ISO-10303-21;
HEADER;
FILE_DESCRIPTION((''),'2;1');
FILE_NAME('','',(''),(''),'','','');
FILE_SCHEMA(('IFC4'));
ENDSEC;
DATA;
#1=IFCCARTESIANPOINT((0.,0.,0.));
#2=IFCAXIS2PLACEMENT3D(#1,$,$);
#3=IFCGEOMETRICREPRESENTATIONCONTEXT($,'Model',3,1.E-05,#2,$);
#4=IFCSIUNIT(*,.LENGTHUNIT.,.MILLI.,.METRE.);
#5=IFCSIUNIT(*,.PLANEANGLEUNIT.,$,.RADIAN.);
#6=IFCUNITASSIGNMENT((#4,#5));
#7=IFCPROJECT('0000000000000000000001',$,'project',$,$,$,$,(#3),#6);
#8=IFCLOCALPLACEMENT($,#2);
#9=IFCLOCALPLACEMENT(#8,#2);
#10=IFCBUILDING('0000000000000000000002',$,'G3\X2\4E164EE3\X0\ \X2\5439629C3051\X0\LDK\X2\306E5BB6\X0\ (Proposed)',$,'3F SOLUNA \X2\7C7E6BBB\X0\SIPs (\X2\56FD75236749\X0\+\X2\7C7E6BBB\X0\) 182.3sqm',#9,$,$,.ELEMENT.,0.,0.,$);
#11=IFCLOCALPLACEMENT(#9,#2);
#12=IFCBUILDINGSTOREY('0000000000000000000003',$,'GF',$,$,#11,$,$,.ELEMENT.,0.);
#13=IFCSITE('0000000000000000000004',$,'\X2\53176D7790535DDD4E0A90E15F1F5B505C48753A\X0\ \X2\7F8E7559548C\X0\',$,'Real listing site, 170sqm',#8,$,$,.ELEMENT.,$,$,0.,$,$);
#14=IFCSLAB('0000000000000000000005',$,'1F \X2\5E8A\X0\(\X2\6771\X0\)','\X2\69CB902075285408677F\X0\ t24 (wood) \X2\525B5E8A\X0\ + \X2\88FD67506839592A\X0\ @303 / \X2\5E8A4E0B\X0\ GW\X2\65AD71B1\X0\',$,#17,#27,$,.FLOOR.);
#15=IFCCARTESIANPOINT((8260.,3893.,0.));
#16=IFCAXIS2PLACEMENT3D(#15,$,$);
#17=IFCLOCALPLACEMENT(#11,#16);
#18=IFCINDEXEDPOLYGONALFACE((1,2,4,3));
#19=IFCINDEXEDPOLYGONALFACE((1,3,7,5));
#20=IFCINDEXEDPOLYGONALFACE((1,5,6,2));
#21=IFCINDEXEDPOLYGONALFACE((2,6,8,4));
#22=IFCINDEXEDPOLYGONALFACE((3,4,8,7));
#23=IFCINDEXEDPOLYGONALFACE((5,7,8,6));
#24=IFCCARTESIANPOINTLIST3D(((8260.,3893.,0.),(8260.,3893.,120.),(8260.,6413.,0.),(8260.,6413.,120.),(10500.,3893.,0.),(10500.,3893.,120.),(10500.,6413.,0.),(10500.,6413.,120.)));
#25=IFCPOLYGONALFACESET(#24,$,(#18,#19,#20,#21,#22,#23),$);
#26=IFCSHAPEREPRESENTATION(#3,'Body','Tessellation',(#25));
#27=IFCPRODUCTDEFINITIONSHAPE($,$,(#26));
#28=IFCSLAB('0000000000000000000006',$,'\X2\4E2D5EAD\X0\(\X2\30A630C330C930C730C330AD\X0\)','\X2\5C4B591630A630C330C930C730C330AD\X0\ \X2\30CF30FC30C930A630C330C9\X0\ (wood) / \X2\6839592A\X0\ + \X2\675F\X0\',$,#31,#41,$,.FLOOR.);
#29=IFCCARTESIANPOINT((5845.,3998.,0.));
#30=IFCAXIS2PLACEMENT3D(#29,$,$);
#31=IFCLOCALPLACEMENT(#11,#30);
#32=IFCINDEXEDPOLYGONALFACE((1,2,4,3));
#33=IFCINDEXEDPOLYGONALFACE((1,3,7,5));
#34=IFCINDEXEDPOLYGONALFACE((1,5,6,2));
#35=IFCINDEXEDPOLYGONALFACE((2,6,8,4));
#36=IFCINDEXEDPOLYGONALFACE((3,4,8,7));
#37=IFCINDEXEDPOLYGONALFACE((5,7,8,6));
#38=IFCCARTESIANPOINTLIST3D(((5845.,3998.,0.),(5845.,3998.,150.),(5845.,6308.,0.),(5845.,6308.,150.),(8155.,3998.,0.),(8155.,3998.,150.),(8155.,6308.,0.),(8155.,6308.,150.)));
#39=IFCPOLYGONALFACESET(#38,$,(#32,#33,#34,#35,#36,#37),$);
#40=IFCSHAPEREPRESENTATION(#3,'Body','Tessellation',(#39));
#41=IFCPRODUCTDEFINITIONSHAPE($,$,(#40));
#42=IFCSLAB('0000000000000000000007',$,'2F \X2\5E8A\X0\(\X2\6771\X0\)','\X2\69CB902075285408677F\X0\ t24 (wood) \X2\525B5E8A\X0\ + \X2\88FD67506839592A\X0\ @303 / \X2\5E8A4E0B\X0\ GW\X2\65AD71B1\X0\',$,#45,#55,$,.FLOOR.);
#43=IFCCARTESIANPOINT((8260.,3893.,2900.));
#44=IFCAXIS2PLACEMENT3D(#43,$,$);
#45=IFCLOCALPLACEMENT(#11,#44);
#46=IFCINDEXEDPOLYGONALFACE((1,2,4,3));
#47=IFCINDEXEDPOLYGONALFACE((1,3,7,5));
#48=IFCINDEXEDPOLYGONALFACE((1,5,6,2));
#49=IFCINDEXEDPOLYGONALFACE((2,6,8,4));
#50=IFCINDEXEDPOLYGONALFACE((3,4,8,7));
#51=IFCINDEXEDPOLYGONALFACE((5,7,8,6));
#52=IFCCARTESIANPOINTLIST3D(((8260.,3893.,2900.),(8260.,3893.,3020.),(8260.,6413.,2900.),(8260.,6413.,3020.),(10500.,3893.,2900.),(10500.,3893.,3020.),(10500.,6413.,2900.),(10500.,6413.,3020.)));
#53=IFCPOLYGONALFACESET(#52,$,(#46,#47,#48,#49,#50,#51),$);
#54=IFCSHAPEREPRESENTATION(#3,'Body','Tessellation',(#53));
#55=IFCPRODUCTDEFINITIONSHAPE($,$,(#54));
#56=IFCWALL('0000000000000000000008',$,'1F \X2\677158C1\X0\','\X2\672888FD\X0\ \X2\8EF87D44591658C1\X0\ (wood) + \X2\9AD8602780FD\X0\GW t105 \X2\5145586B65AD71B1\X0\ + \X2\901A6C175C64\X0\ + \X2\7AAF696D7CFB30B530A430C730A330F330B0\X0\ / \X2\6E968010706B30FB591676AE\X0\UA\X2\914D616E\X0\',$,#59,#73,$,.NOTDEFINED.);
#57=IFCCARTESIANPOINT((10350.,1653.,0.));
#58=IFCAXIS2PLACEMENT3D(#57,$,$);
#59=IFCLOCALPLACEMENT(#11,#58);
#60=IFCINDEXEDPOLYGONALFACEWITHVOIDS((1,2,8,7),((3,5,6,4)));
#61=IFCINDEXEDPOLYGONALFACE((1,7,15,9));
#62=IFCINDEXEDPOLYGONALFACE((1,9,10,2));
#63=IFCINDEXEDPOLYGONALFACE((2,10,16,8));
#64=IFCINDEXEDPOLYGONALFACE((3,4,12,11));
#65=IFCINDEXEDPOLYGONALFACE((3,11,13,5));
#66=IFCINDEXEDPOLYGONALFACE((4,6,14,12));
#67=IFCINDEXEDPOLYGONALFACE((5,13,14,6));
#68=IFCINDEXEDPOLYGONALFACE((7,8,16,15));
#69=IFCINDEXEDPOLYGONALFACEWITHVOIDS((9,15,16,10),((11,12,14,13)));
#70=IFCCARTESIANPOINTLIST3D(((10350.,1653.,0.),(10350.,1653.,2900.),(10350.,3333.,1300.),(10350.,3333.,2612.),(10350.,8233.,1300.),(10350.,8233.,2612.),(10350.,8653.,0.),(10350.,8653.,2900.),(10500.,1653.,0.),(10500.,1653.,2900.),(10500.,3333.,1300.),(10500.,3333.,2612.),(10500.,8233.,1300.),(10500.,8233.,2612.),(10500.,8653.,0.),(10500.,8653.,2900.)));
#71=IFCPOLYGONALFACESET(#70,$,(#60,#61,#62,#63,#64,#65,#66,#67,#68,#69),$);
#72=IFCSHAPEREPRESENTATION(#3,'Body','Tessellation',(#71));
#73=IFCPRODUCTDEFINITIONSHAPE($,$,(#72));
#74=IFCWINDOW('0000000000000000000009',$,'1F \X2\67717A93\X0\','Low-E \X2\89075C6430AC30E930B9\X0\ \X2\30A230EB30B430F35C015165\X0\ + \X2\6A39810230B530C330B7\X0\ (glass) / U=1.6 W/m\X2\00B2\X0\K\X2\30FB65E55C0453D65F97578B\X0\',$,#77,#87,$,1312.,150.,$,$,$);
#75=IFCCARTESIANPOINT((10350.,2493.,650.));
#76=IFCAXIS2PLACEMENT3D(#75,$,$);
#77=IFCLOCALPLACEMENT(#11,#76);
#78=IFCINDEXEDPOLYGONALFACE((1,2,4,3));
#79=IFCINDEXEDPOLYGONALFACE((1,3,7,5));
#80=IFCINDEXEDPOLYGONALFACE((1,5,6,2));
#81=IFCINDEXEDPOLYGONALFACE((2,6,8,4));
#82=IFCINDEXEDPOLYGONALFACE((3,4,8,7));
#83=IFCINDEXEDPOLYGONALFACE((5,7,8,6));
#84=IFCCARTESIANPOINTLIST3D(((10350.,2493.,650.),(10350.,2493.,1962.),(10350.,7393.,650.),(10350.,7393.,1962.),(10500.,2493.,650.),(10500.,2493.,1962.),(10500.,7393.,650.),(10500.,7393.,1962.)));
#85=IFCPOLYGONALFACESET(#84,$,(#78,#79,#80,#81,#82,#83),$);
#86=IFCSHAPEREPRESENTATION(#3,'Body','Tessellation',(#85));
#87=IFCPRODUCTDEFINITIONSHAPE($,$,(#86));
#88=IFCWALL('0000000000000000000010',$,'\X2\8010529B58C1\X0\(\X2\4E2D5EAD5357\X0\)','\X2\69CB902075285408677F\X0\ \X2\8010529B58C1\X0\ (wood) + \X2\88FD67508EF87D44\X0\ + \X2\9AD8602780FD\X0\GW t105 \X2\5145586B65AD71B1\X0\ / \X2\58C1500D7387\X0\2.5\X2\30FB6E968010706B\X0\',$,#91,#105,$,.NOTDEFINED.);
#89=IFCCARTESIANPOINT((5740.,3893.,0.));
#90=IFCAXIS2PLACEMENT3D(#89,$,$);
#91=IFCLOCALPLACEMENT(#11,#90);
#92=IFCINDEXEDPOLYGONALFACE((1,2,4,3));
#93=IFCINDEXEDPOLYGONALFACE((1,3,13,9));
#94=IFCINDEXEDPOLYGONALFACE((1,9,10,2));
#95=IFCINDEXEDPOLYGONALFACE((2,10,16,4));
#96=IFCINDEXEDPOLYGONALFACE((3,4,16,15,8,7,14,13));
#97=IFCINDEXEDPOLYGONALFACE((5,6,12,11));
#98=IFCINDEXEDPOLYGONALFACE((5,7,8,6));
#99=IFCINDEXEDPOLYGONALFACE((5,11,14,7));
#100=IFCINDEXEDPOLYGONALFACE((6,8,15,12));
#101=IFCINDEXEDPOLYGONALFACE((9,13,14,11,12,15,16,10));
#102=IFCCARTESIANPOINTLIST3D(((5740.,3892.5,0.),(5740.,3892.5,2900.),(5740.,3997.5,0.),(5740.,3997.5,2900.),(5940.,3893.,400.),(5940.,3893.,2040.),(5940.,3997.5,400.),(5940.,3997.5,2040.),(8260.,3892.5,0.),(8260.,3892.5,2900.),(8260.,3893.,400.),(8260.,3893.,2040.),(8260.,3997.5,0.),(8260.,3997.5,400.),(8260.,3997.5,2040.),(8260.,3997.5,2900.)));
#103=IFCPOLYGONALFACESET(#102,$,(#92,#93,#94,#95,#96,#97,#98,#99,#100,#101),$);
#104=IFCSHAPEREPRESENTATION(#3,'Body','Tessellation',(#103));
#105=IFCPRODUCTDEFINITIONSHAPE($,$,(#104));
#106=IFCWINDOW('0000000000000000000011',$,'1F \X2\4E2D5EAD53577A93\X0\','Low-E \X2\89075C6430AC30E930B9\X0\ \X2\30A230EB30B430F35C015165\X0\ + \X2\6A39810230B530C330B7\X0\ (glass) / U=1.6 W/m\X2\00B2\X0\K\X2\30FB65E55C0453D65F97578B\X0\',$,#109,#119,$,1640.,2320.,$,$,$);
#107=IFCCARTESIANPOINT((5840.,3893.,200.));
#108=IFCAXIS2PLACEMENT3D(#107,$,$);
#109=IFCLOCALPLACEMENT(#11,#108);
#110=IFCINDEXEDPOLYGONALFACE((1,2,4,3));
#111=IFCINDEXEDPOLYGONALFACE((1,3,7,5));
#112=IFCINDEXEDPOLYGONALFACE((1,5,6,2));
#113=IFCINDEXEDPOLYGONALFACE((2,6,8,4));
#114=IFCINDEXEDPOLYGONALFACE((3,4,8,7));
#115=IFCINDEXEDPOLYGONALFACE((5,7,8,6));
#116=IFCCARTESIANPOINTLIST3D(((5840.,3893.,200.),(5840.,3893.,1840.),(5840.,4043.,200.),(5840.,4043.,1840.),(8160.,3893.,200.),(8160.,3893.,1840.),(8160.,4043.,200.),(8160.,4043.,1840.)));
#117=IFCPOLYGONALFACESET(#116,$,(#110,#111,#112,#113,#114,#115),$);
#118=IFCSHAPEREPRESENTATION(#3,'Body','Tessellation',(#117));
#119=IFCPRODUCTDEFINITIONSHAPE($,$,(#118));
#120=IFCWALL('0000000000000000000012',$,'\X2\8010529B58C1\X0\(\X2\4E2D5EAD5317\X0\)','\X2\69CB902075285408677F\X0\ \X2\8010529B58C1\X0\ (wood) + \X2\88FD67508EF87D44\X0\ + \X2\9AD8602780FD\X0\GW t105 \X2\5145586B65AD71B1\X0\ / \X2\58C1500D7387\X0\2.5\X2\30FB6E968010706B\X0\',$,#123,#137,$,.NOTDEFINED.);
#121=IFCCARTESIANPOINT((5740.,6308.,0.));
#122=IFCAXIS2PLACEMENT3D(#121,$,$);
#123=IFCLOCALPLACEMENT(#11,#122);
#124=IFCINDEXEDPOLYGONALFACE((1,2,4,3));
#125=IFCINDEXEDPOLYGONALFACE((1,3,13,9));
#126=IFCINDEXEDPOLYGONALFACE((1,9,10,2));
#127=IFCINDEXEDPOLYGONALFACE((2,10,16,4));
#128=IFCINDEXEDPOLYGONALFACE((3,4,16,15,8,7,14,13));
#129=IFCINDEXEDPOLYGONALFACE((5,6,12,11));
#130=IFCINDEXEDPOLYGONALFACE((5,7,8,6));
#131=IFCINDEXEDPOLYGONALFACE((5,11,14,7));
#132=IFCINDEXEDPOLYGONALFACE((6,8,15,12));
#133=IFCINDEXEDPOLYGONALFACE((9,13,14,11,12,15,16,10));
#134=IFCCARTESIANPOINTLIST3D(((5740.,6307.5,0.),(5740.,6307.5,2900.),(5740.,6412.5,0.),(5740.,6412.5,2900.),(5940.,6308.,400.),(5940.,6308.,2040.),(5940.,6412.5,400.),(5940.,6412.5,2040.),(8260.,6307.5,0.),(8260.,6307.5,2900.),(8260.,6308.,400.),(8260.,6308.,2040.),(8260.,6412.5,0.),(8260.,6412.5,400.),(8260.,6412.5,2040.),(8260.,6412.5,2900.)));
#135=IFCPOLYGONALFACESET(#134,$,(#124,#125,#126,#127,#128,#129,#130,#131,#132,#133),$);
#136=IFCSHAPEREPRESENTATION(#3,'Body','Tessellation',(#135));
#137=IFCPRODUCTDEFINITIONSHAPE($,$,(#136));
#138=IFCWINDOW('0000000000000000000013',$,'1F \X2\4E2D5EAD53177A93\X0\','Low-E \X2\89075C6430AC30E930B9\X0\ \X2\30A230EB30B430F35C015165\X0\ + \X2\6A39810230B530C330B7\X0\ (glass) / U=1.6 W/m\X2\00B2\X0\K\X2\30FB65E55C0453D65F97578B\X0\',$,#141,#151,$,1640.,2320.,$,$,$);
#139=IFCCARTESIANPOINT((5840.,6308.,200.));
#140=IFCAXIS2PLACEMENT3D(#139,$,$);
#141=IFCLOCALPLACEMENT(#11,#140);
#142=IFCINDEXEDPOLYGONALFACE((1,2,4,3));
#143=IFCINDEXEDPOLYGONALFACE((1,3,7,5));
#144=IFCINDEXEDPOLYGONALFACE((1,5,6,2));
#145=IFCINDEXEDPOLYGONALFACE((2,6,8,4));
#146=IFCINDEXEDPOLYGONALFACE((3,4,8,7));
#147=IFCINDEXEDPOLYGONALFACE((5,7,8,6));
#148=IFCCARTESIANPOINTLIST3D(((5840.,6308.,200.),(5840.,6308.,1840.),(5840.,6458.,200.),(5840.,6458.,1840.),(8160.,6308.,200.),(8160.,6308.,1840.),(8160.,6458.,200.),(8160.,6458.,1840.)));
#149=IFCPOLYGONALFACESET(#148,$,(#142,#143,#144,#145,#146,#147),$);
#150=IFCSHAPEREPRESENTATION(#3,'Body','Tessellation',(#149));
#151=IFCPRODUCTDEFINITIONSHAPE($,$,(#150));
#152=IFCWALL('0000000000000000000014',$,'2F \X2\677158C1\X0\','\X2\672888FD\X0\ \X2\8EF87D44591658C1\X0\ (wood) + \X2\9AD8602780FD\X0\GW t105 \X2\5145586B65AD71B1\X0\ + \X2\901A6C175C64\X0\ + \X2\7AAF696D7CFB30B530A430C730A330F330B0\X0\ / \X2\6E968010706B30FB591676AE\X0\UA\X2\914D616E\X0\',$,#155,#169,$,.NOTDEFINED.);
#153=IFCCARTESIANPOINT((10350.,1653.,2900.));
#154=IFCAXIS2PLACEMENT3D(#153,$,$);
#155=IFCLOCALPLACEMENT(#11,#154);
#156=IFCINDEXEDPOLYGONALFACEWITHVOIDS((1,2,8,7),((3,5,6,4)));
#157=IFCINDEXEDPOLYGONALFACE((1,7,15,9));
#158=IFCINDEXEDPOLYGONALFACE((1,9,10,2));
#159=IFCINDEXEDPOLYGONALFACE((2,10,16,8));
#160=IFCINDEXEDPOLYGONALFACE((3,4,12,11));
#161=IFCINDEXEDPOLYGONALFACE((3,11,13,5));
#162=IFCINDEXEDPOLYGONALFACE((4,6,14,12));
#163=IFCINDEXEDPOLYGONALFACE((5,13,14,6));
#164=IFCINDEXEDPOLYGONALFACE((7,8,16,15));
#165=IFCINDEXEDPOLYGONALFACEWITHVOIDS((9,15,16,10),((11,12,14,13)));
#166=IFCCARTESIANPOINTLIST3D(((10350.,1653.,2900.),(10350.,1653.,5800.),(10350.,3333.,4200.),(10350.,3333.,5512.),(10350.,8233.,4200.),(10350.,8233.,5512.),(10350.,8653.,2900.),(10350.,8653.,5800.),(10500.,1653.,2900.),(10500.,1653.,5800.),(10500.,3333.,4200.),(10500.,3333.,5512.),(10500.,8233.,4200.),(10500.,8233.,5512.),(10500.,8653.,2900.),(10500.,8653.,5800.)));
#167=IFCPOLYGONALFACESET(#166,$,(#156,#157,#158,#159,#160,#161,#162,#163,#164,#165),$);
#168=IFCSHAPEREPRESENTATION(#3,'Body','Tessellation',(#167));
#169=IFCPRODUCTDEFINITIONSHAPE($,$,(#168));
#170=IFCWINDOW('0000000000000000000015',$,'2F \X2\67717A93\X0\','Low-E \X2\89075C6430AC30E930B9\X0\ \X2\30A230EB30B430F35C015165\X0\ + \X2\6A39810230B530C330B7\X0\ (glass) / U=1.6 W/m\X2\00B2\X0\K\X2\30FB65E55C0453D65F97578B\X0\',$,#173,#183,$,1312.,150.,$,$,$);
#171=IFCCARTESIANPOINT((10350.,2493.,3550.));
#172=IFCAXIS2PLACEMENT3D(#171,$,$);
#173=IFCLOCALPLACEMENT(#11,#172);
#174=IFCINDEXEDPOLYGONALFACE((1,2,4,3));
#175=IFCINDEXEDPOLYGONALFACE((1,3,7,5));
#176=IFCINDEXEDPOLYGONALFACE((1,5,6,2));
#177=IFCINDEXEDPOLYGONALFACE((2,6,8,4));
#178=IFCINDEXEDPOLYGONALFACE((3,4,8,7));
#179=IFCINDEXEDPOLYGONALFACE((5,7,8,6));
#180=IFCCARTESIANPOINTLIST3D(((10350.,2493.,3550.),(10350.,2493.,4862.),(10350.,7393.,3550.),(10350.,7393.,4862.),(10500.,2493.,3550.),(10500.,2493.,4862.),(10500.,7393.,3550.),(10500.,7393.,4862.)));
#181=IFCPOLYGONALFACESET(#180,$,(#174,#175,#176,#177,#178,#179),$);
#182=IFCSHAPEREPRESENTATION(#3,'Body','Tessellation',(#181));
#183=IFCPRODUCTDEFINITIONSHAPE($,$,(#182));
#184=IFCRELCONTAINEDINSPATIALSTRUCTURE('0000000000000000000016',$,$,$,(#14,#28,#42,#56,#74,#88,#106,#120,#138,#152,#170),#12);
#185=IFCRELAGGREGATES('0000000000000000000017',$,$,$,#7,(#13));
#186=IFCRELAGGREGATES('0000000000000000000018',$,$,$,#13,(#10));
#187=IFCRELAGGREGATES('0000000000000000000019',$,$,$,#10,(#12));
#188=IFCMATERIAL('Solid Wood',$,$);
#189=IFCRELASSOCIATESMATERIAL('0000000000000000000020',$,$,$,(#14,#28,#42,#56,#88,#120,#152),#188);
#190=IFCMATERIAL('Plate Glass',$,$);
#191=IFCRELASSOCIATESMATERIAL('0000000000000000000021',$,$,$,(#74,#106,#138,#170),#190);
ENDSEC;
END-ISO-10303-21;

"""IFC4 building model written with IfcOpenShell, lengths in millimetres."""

from ifc_helpers import new_model, si_unit, frame, frame_2d, origin, place, context, project, spatial, rectangle, extrude, material, element, fill, save


model = new_model("IFC4")

# Units and contexts
model_context = context("Model", 3, precision=1e-05, world=origin())
ifc_project = project(units=[si_unit("LENGTHUNIT", "METRE", prefix="MILLI"), si_unit("PLANEANGLEUNIT", "RADIAN")], contexts=[model_context])

# Site, building, storey
site_placement = place(None, origin())
site = spatial("IfcSite", under=ifc_project, at=site_placement, Name="北海道川上郡弟子屈町 美留和", ObjectType="Real listing site, 170sqm", CompositionType="ELEMENT", RefElevation=0.0)
building_placement = place(site_placement, origin())
building = spatial("IfcBuilding", under=site, at=building_placement, Name="G3世代 吹抜けLDKの家 (Proposed)", ObjectType="3F SOLUNA 籾殻SIPs (国産杉+籾殻) 182.3sqm", CompositionType="ELEMENT", ElevationOfRefHeight=0.0, ElevationOfTerrain=0.0)
storey_placement = place(building_placement, origin())
storey = spatial("IfcBuildingStorey", under=building, at=storey_placement, Name="GF", CompositionType="ELEMENT", Elevation=0.0)

# Slabs
ifc_material_1 = material(Name="Solid Wood")
slab_1_placement = place(storey_placement, frame((8260.0, 3893.0, 0.0)))
element("IfcSlab", 1, at=slab_1_placement, inside=storey, material=ifc_material_1, Name="1F 床(東)", Description="構造用合板 t24 (wood) 剛床 + 製材根太 @303 / 床下 GW断熱", PredefinedType="FLOOR", context=model_context, shape_type="SweptSolid", body=[
    extrude(rectangle(XDim=2240.0, YDim=2520.0, at=frame_2d((1120.0, 1260.0))), frame((8260.0, 3893.0, 0.0)), (0.0, 0.0, 1.0), 120.0),
])
slab_2_placement = place(storey_placement, frame((5845.0, 3998.0, 0.0)))
element("IfcSlab", 2, at=slab_2_placement, inside=storey, material=ifc_material_1, Name="中庭(ウッドデッキ)", Description="屋外ウッドデッキ ハードウッド (wood) / 根太 + 束", PredefinedType="FLOOR", context=model_context, shape_type="SweptSolid", body=[
    extrude(rectangle(XDim=2310.0, YDim=2310.0, at=frame_2d((1155.0, 1155.0))), frame((5845.0, 3998.0, 0.0)), (0.0, 0.0, 1.0), 150.0),
])
slab_3_placement = place(storey_placement, frame((8260.0, 3893.0, 2900.0)))
element("IfcSlab", 3, at=slab_3_placement, inside=storey, material=ifc_material_1, Name="2F 床(東)", Description="構造用合板 t24 (wood) 剛床 + 製材根太 @303 / 床下 GW断熱", PredefinedType="FLOOR", context=model_context, shape_type="SweptSolid", body=[
    extrude(rectangle(XDim=2240.0, YDim=2520.0, at=frame_2d((1120.0, 1260.0))), frame((8260.0, 3893.0, 2900.0)), (0.0, 0.0, 1.0), 120.0),
])

# Walls, openings, windows
wall_1_placement = place(storey_placement, frame((10350.0, 1653.0, 0.0)))
wall_1 = element("IfcWall", 4, at=wall_1_placement, inside=storey, material=ifc_material_1, Name="1F 東壁", Description="木製 軸組外壁 (wood) + 高性能GW t105 充填断熱 + 通気層 + 窯業系サイディング / 準耐火・外皮UA配慮", PredefinedType="NOTDEFINED", context=model_context, shape_type="SweptSolid", body=[
    extrude(rectangle(XDim=150.0, YDim=7000.0, at=frame_2d((75.0, 3500.0))), frame((10350.0, 1653.0, 0.0)), (0.0, 0.0, 1.0), 2900.0),
])
opening_1_placement = place(storey_placement, frame((10350.0, 2493.0, 650.0)))
opening_1 = element("IfcOpeningElement", 5, at=opening_1_placement, cuts=wall_1, PredefinedType="NOTDEFINED", context=model_context, shape_type="SweptSolid", body=[
    extrude(rectangle(XDim=150.0, YDim=4900.0, at=frame_2d((75.0, 2450.0))), frame((10350.0, 2493.0, 650.0)), (0.0, 0.0, 1.0), 1312.0),
])
ifc_material_2 = material(Name="Plate Glass")
window_1_placement = place(storey_placement, frame((10350.0, 2493.0, 650.0)))
window_1 = element("IfcWindow", 6, at=window_1_placement, inside=storey, material=ifc_material_2, Name="1F 東窓", Description="Low-E 複層ガラス アルゴン封入 + 樹脂サッシ (glass) / U=1.6 W/m²K・日射取得型", OverallHeight=1312.0, OverallWidth=150.0, context=model_context, shape_type="SweptSolid", body=[
    extrude(rectangle(XDim=150.0, YDim=4900.0, at=frame_2d((75.0, 2450.0))), frame((10350.0, 2493.0, 650.0)), (0.0, 0.0, 1.0), 1312.0),
])
fill(opening_1, window_1)
wall_2_placement = place(storey_placement, frame((5740.0, 3893.0, 0.0)))
wall_2 = element("IfcWall", 7, at=wall_2_placement, inside=storey, material=ifc_material_1, Name="耐力壁(中庭南)", Description="構造用合板 耐力壁 (wood) + 製材軸組 + 高性能GW t105 充填断熱 / 壁倍率2.5・準耐火", PredefinedType="NOTDEFINED", context=model_context, shape_type="SweptSolid", body=[
    extrude(rectangle(XDim=2520.0, YDim=105.0, at=frame_2d((1260.0, 52.0))), frame((5740.0, 3893.0, 0.0)), (0.0, 0.0, 1.0), 2900.0),
])
opening_2_placement = place(storey_placement, frame((5840.0, 3893.0, 200.0)))
opening_2 = element("IfcOpeningElement", 8, at=opening_2_placement, cuts=wall_2, PredefinedType="NOTDEFINED", context=model_context, shape_type="SweptSolid", body=[
    extrude(rectangle(XDim=2320.0, YDim=150.0, at=frame_2d((1160.0, 75.0))), frame((5840.0, 3893.0, 200.0)), (0.0, 0.0, 1.0), 1640.0),
])
window_2_placement = place(storey_placement, frame((5840.0, 3893.0, 200.0)))
window_2 = element("IfcWindow", 9, at=window_2_placement, inside=storey, material=ifc_material_2, Name="1F 中庭南窓", Description="Low-E 複層ガラス アルゴン封入 + 樹脂サッシ (glass) / U=1.6 W/m²K・日射取得型", OverallHeight=1640.0, OverallWidth=2320.0, context=model_context, shape_type="SweptSolid", body=[
    extrude(rectangle(XDim=2320.0, YDim=150.0, at=frame_2d((1160.0, 75.0))), frame((5840.0, 3893.0, 200.0)), (0.0, 0.0, 1.0), 1640.0),
])
fill(opening_2, window_2)
wall_3_placement = place(storey_placement, frame((5740.0, 6308.0, 0.0)))
wall_3 = element("IfcWall", 10, at=wall_3_placement, inside=storey, material=ifc_material_1, Name="耐力壁(中庭北)", Description="構造用合板 耐力壁 (wood) + 製材軸組 + 高性能GW t105 充填断熱 / 壁倍率2.5・準耐火", PredefinedType="NOTDEFINED", context=model_context, shape_type="SweptSolid", body=[
    extrude(rectangle(XDim=2520.0, YDim=105.0, at=frame_2d((1260.0, 52.0))), frame((5740.0, 6308.0, 0.0)), (0.0, 0.0, 1.0), 2900.0),
])
opening_3_placement = place(storey_placement, frame((5840.0, 6308.0, 200.0)))
opening_3 = element("IfcOpeningElement", 11, at=opening_3_placement, cuts=wall_3, PredefinedType="NOTDEFINED", context=model_context, shape_type="SweptSolid", body=[
    extrude(rectangle(XDim=2320.0, YDim=150.0, at=frame_2d((1160.0, 75.0))), frame((5840.0, 6308.0, 200.0)), (0.0, 0.0, 1.0), 1640.0),
])
window_3_placement = place(storey_placement, frame((5840.0, 6308.0, 200.0)))
window_3 = element("IfcWindow", 12, at=window_3_placement, inside=storey, material=ifc_material_2, Name="1F 中庭北窓", Description="Low-E 複層ガラス アルゴン封入 + 樹脂サッシ (glass) / U=1.6 W/m²K・日射取得型", OverallHeight=1640.0, OverallWidth=2320.0, context=model_context, shape_type="SweptSolid", body=[
    extrude(rectangle(XDim=2320.0, YDim=150.0, at=frame_2d((1160.0, 75.0))), frame((5840.0, 6308.0, 200.0)), (0.0, 0.0, 1.0), 1640.0),
])
fill(opening_3, window_3)

# Wall, opening, window
wall_4_placement = place(storey_placement, frame((10350.0, 1653.0, 2900.0)))
wall_4 = element("IfcWall", 13, at=wall_4_placement, inside=storey, material=ifc_material_1, Name="2F 東壁", Description="木製 軸組外壁 (wood) + 高性能GW t105 充填断熱 + 通気層 + 窯業系サイディング / 準耐火・外皮UA配慮", PredefinedType="NOTDEFINED", context=model_context, shape_type="SweptSolid", body=[
    extrude(rectangle(XDim=150.0, YDim=7000.0, at=frame_2d((75.0, 3500.0))), frame((10350.0, 1653.0, 2900.0)), (0.0, 0.0, 1.0), 2900.0),
])
opening_4_placement = place(storey_placement, frame((10350.0, 2493.0, 3550.0)))
opening_4 = element("IfcOpeningElement", 14, at=opening_4_placement, cuts=wall_4, PredefinedType="NOTDEFINED", context=model_context, shape_type="SweptSolid", body=[
    extrude(rectangle(XDim=150.0, YDim=4900.0, at=frame_2d((75.0, 2450.0))), frame((10350.0, 2493.0, 3550.0)), (0.0, 0.0, 1.0), 1312.0),
])
window_4_placement = place(storey_placement, frame((10350.0, 2493.0, 3550.0)))
window_4 = element("IfcWindow", 15, at=window_4_placement, inside=storey, material=ifc_material_2, Name="2F 東窓", Description="Low-E 複層ガラス アルゴン封入 + 樹脂サッシ (glass) / U=1.6 W/m²K・日射取得型", OverallHeight=1312.0, OverallWidth=150.0, context=model_context, shape_type="SweptSolid", body=[
    extrude(rectangle(XDim=150.0, YDim=4900.0, at=frame_2d((75.0, 2450.0))), frame((10350.0, 2493.0, 3550.0)), (0.0, 0.0, 1.0), 1312.0),
])
fill(opening_4, window_4)

save(model, "model.ifc")
